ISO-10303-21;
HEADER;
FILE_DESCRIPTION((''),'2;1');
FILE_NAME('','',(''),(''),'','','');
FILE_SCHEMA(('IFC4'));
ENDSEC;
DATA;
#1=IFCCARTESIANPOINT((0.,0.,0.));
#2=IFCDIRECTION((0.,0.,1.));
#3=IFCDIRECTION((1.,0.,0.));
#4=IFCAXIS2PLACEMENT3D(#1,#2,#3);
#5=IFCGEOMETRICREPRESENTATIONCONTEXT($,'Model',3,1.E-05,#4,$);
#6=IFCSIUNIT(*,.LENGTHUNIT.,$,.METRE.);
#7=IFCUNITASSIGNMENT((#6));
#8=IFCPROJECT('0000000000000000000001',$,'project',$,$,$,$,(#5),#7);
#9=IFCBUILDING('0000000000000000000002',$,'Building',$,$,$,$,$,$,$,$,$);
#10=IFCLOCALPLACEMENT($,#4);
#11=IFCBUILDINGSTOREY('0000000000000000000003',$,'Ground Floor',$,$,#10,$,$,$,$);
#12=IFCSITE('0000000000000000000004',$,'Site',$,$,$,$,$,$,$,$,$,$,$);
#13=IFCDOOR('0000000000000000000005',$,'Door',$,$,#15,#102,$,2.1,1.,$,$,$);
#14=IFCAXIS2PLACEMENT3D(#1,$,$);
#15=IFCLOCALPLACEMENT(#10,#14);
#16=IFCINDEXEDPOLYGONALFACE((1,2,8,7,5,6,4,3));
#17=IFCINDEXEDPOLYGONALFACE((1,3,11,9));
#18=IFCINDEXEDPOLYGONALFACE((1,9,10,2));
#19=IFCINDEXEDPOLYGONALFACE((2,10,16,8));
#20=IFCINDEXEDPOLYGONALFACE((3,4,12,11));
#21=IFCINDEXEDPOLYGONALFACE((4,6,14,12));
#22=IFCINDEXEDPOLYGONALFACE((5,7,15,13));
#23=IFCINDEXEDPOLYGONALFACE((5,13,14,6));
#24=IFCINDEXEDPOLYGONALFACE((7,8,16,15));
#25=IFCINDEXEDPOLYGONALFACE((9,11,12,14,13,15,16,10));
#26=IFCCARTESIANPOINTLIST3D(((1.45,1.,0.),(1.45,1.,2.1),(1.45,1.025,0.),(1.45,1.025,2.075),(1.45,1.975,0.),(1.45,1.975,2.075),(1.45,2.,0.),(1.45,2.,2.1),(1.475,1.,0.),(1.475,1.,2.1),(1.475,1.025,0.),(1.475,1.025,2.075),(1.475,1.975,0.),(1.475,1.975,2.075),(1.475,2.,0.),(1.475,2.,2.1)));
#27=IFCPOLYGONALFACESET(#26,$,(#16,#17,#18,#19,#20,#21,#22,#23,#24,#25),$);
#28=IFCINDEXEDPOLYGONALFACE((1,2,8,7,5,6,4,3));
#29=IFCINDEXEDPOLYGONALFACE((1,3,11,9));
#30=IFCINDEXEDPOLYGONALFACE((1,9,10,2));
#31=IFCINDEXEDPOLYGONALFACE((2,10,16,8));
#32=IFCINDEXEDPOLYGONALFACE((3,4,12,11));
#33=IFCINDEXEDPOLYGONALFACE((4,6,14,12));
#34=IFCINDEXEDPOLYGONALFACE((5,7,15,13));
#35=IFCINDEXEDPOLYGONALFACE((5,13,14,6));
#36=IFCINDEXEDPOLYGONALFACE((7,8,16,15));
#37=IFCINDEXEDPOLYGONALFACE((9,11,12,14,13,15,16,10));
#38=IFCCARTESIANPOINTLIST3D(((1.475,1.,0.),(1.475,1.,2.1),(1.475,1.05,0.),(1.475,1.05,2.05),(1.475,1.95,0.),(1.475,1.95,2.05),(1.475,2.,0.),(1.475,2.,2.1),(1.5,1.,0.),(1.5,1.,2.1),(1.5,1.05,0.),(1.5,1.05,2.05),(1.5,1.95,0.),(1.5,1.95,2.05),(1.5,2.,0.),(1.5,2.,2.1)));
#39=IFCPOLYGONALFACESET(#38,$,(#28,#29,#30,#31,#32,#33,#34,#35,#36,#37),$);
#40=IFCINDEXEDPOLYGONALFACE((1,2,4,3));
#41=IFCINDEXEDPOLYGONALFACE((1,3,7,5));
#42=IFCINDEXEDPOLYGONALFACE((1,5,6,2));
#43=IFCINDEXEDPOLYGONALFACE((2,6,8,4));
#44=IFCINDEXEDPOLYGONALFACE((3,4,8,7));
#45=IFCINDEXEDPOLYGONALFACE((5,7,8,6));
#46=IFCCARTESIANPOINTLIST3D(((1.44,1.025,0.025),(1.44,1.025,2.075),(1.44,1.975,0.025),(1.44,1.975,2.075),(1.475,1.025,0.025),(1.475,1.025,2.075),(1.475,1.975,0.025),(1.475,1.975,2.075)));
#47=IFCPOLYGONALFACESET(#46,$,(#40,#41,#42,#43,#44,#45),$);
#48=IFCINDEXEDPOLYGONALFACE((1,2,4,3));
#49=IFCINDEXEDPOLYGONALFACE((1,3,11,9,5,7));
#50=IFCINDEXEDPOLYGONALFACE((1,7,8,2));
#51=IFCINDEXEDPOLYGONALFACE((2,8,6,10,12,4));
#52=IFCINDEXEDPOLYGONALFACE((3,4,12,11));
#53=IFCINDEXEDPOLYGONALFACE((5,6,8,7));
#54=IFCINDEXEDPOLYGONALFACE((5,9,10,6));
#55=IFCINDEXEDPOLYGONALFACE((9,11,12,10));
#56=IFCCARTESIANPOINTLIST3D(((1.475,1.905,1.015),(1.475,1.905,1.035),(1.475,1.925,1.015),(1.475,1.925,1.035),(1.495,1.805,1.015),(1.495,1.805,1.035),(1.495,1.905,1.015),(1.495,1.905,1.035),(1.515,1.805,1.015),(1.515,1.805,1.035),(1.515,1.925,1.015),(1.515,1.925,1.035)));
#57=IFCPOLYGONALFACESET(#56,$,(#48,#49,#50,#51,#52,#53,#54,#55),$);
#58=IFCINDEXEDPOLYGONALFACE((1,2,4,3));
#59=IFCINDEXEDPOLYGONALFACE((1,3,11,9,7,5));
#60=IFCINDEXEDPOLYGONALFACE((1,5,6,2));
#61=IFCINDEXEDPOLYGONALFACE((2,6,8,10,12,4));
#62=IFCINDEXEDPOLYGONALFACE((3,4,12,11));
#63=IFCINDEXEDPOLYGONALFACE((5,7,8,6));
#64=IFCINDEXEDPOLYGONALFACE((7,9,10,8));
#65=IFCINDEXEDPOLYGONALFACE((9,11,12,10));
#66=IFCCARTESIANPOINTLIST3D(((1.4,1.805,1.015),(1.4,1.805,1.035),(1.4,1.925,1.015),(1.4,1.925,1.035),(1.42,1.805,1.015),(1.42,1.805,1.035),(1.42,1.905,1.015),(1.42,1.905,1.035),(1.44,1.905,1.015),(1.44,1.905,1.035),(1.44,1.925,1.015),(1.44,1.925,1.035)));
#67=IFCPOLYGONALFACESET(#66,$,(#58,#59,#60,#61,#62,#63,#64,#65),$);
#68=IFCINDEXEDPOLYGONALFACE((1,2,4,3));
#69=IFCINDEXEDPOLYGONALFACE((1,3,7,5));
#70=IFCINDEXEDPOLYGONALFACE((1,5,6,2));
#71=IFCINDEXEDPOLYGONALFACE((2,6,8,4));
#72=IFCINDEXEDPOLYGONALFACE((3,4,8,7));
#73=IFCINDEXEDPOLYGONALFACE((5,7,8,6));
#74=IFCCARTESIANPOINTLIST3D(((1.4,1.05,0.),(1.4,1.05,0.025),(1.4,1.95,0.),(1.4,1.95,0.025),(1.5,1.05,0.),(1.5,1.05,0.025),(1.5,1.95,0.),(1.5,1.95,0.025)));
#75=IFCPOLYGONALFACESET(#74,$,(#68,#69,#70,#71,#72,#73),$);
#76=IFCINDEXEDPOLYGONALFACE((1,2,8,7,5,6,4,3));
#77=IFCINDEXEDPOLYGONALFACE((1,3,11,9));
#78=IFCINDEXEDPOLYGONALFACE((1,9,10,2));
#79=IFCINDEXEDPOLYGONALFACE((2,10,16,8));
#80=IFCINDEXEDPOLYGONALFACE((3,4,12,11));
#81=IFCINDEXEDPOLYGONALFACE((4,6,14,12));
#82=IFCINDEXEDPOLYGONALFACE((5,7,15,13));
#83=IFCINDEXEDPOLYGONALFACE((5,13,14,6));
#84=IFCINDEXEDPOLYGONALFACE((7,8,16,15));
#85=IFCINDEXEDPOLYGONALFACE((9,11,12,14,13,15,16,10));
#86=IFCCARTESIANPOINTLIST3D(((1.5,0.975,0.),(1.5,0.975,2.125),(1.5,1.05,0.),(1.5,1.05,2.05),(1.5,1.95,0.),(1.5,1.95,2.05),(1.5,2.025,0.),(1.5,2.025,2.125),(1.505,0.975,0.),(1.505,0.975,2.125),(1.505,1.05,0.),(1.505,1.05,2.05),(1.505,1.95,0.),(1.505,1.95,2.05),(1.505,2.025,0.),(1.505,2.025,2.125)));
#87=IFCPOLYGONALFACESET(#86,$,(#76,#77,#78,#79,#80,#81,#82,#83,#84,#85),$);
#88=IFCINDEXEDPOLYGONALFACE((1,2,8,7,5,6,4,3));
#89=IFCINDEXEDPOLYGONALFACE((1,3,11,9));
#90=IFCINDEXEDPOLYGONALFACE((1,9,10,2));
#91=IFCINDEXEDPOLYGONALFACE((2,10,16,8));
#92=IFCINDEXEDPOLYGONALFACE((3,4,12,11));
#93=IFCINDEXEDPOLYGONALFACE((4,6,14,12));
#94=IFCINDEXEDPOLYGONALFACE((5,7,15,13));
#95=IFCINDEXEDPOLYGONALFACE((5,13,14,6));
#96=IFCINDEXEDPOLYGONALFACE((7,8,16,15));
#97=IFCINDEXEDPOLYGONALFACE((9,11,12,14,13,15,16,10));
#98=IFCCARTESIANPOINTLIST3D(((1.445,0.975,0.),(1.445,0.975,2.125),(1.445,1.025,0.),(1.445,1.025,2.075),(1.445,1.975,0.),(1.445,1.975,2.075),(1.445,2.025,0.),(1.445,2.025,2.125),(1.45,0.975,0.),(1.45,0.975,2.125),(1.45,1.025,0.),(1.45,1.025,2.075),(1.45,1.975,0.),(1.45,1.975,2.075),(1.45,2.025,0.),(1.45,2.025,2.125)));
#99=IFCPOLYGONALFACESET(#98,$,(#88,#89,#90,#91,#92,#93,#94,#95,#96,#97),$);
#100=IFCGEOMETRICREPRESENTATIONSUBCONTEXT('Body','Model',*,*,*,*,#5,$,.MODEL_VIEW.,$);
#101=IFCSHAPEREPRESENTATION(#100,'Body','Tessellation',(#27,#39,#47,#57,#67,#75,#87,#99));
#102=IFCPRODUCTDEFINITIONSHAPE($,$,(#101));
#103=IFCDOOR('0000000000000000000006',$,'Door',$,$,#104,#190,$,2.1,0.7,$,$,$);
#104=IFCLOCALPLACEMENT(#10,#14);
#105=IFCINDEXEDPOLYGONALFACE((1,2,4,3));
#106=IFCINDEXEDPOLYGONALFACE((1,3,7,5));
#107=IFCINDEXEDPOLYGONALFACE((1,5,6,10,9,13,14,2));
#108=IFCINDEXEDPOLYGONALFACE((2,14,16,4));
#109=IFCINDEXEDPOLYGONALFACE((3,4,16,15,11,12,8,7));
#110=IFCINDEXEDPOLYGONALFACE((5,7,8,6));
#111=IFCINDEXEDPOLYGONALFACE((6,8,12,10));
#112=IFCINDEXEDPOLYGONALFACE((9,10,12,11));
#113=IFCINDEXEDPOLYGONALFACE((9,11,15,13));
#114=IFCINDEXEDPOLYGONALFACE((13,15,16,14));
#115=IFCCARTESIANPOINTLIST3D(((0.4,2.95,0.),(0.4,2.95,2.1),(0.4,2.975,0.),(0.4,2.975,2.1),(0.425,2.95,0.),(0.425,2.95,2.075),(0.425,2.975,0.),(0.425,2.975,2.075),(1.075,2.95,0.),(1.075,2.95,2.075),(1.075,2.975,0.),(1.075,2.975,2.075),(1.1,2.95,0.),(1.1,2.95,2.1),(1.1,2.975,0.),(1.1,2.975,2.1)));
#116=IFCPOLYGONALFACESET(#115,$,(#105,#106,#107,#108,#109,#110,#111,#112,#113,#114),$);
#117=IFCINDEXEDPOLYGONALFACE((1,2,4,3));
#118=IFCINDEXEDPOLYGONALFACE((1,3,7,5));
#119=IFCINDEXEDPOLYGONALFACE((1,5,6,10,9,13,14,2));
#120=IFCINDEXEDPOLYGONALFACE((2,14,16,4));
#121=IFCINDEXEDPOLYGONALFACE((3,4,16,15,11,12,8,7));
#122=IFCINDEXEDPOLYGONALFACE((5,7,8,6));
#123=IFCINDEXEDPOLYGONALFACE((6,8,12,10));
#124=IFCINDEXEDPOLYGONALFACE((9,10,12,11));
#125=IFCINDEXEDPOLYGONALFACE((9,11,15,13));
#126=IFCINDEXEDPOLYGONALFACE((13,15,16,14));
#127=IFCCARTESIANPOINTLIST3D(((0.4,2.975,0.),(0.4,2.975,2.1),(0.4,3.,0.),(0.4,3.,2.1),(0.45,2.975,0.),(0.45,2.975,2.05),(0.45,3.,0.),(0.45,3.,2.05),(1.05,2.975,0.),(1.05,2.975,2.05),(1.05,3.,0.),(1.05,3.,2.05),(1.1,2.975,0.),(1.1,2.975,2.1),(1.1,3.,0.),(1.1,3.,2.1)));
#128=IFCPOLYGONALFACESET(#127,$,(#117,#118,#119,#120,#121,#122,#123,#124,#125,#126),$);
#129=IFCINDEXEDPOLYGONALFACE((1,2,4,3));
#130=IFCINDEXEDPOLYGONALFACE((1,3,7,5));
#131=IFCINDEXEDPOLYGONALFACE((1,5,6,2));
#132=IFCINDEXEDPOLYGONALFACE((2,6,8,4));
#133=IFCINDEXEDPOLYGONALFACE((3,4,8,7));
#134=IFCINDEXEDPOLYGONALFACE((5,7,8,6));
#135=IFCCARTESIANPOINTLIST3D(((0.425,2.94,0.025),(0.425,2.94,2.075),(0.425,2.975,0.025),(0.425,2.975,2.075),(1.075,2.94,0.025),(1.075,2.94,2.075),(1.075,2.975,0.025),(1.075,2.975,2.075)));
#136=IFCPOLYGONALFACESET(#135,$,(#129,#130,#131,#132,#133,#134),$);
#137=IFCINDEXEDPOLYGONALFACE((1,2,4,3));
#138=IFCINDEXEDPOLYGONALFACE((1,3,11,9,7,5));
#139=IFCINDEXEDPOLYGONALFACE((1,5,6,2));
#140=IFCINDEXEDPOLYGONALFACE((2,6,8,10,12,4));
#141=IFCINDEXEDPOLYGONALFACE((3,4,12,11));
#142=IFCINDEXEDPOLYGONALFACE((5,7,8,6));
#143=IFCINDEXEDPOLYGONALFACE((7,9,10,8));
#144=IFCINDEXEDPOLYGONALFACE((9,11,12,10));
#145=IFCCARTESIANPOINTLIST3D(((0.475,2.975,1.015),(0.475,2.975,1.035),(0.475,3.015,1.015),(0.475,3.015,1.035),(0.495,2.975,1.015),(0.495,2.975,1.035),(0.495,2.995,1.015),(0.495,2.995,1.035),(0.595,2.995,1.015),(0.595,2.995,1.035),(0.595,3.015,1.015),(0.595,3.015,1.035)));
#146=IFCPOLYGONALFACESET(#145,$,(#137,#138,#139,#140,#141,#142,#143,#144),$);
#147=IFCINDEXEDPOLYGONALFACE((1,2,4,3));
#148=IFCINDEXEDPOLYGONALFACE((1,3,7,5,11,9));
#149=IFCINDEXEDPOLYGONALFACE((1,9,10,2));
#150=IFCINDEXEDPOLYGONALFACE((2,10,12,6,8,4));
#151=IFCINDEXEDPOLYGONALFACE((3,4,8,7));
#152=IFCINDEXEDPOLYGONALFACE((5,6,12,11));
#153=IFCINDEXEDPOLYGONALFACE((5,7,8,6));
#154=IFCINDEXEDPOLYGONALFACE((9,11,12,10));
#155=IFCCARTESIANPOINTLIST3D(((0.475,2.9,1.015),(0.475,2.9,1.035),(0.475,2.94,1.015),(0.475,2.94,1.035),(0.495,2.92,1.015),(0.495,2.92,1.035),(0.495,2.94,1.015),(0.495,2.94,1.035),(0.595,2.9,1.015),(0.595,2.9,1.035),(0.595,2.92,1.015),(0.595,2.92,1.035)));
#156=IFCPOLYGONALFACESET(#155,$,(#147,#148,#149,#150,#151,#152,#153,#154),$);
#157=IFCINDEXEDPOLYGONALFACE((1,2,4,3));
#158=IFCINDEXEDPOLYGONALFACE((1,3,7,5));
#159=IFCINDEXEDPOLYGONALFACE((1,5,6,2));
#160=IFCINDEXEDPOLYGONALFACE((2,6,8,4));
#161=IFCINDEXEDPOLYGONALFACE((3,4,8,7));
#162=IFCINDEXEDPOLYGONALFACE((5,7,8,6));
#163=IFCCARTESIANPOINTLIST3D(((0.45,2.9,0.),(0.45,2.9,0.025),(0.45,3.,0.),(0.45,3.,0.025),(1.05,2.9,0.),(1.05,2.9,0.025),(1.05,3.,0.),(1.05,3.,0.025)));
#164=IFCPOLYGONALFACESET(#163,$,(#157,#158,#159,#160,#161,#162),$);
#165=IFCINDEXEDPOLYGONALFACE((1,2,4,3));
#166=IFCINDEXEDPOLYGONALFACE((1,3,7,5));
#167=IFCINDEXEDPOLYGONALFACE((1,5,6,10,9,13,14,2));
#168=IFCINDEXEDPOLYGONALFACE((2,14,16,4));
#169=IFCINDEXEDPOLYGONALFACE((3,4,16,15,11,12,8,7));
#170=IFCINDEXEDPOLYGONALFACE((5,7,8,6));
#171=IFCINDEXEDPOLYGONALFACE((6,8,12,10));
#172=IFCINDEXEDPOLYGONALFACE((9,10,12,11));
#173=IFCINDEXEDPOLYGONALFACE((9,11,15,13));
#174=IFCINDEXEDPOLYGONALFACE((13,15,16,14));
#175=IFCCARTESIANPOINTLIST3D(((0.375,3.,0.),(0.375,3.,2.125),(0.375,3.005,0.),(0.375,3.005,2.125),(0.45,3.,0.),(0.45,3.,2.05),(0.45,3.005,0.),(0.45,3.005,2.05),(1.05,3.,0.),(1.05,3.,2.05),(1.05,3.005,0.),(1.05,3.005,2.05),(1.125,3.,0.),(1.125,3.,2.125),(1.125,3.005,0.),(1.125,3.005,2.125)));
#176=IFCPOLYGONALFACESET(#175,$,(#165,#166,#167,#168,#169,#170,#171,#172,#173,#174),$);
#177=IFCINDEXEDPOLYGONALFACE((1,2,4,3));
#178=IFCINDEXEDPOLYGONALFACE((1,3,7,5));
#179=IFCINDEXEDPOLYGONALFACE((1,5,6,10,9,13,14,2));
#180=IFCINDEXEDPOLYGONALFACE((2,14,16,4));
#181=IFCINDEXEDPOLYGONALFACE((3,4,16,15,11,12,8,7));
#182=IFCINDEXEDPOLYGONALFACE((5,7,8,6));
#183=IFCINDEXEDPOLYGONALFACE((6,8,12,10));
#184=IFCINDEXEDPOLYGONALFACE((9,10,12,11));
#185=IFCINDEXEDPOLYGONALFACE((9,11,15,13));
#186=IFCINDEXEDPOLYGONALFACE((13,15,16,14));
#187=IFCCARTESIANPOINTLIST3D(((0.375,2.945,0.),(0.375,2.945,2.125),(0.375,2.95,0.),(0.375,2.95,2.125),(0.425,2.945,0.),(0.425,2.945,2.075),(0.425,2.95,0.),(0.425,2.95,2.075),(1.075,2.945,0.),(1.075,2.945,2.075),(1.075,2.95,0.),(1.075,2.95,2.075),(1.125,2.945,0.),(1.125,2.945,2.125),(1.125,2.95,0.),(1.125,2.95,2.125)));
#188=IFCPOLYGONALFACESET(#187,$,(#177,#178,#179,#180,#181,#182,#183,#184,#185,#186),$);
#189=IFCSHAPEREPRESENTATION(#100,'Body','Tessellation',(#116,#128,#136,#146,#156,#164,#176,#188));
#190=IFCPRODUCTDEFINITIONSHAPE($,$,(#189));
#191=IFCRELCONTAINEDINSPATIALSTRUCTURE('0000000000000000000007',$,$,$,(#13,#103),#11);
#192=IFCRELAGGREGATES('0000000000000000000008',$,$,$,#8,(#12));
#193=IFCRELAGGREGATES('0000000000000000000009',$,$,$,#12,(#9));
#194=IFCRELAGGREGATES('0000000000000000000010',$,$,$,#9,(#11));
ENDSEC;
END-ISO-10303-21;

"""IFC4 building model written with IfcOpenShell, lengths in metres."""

from ifc_helpers import new_model, si_unit, frame, origin_with_axes, place, context, subcontext, project, spatial, line, indexed_curve, outline, extrude, element, save


model = new_model("IFC4")

# Units and contexts
model_context = context("Model", 3, precision=1e-05, world=origin_with_axes())
body_context = subcontext(model_context, "Body", "Model", "MODEL_VIEW")
ifc_project = project(units=[si_unit("LENGTHUNIT", "METRE")], contexts=[model_context])

# Site, building, storey
site = spatial("IfcSite", under=ifc_project, Name="Site")
building = spatial("IfcBuilding", under=site, Name="Building")
storey_placement = place(None, origin_with_axes())
storey = spatial("IfcBuildingStorey", under=building, at=storey_placement, Name="Ground Floor")

# Doors
door_1_placement = place(storey_placement, frame((1.5, 1.0, 0.0), z_axis=(0.0, 0.0, 1.0), x_axis=(0.0, 1.0, 0.0)))
element("IfcDoor", 1, at=door_1_placement, inside=storey, Name="Door", OverallHeight=2.1, OverallWidth=1.0, context=body_context, shape_type="SweptSolid", body=[
    extrude(outline(indexed_curve([(0.0, 0.0), (0.0, 2.1), (1.0, 2.1), (1.0, 0.0), (0.975, 0.0), (0.975, 2.075), (0.025, 2.075), (0.025, 0.0)], segments=[line(1, 2, 3, 4, 5, 6, 7, 8, 1)])), frame((0.0, 0.025, 0.0), z_axis=(0.0, -1.0, 0.0), x_axis=(1.0, 0.0, 0.0)), (0.0, 0.0, -1.0), 0.025),
    extrude(outline(indexed_curve([(0.0, 0.0), (0.0, 2.1), (1.0, 2.1), (1.0, 0.0), (0.95, 0.0), (0.95, 2.05), (0.05, 2.05), (0.05, 0.0)], segments=[line(1, 2, 3, 4, 5, 6, 7, 8, 1)])), frame((0.0, 0.0, 0.0), z_axis=(0.0, -1.0, 0.0), x_axis=(1.0, 0.0, 0.0)), (0.0, 0.0, -1.0), 0.025),
    extrude(outline(indexed_curve([(0.0, 0.0), (0.95, 0.0), (0.95, 0.035), (0.0, 0.035)], segments=[line(1, 2, 3, 4, 1)])), frame((0.025, 0.025, 0.025), z_axis=(0.0, 0.0, 1.0), x_axis=(1.0, 0.0, 0.0)), (0.0, 0.0, 1.0), 2.05),
    extrude(outline(indexed_curve([(0.0, 0.0), (0.0, -0.04), (-0.12, -0.04), (-0.12, -0.02), (-0.02, -0.02), (-0.02, 0.0)], segments=[line(1, 2, 3, 4, 5, 6, 1)])), frame((0.925, 0.025, 1.015), z_axis=(0.0, 0.0, 1.0), x_axis=(1.0, 0.0, 0.0)), (0.0, 0.0, 1.0), 0.02),
    extrude(outline(indexed_curve([(0.0, 0.0), (0.0, 0.04), (-0.12, 0.04), (-0.12, 0.02), (-0.02, 0.02), (-0.02, 0.0)], segments=[line(1, 2, 3, 4, 5, 6, 1)])), frame((0.925, 0.06, 1.015), z_axis=(0.0, 0.0, 1.0), x_axis=(1.0, 0.0, 0.0)), (0.0, 0.0, 1.0), 0.02),
    extrude(outline(indexed_curve([(0.0, 0.0), (0.9, 0.0), (0.9, 0.1), (0.0, 0.1)], segments=[line(1, 2, 3, 4, 1)])), frame((0.05, 0.0, 0.0), z_axis=(0.0, 0.0, 1.0), x_axis=(1.0, 0.0, 0.0)), (0.0, 0.0, 1.0), 0.025),
    extrude(outline(indexed_curve([(0.0, 0.0), (0.0, 2.125), (1.05, 2.125), (1.05, 0.0), (0.975, 0.0), (0.975, 2.05), (0.075, 2.05), (0.075, 0.0)], segments=[line(1, 2, 3, 4, 5, 6, 7, 8, 1)])), frame((-0.025, -0.005, 0.0), z_axis=(0.0, -1.0, 0.0), x_axis=(1.0, 0.0, 0.0)), (0.0, 0.0, -1.0), 0.005),
    extrude(outline(indexed_curve([(0.0, 0.0), (0.0, 2.125), (1.05, 2.125), (1.05, 0.0), (1.0, 0.0), (1.0, 2.075), (0.05, 2.075), (0.05, 0.0)], segments=[line(1, 2, 3, 4, 5, 6, 7, 8, 1)])), frame((-0.025, 0.05, 0.0), z_axis=(0.0, -1.0, 0.0), x_axis=(1.0, 0.0, 0.0)), (0.0, 0.0, -1.0), 0.005),
])
door_2_placement = place(storey_placement, frame((1.1, 3.0, 0.0), z_axis=(0.0, 0.0, 1.0), x_axis=(-1.0, 0.0, 0.0)))
element("IfcDoor", 2, at=door_2_placement, inside=storey, Name="Door", OverallHeight=2.1, OverallWidth=0.7, context=body_context, shape_type="SweptSolid", body=[
    extrude(outline(indexed_curve([(0.0, 0.0), (0.0, 2.1), (0.7, 2.1), (0.7, 0.0), (0.675, 0.0), (0.675, 2.075), (0.025, 2.075), (0.025, 0.0)], segments=[line(1, 2, 3, 4, 5, 6, 7, 8, 1)])), frame((0.0, 0.025, 0.0), z_axis=(0.0, -1.0, 0.0), x_axis=(1.0, 0.0, 0.0)), (0.0, 0.0, -1.0), 0.025),
    extrude(outline(indexed_curve([(0.0, 0.0), (0.0, 2.1), (0.7, 2.1), (0.7, 0.0), (0.65, 0.0), (0.65, 2.05), (0.05, 2.05), (0.05, 0.0)], segments=[line(1, 2, 3, 4, 5, 6, 7, 8, 1)])), frame((0.0, 0.0, 0.0), z_axis=(0.0, -1.0, 0.0), x_axis=(1.0, 0.0, 0.0)), (0.0, 0.0, -1.0), 0.025),
    extrude(outline(indexed_curve([(0.0, 0.0), (0.65, 0.0), (0.65, 0.035), (0.0, 0.035)], segments=[line(1, 2, 3, 4, 1)])), frame((0.025, 0.025, 0.025), z_axis=(0.0, 0.0, 1.0), x_axis=(1.0, 0.0, 0.0)), (0.0, 0.0, 1.0), 2.05),
    extrude(outline(indexed_curve([(0.0, 0.0), (0.0, -0.04), (-0.12, -0.04), (-0.12, -0.02), (-0.02, -0.02), (-0.02, 0.0)], segments=[line(1, 2, 3, 4, 5, 6, 1)])), frame((0.625, 0.025, 1.015), z_axis=(0.0, 0.0, 1.0), x_axis=(1.0, 0.0, 0.0)), (0.0, 0.0, 1.0), 0.02),
    extrude(outline(indexed_curve([(0.0, 0.0), (0.0, 0.04), (-0.12, 0.04), (-0.12, 0.02), (-0.02, 0.02), (-0.02, 0.0)], segments=[line(1, 2, 3, 4, 5, 6, 1)])), frame((0.625, 0.06, 1.015), z_axis=(0.0, 0.0, 1.0), x_axis=(1.0, 0.0, 0.0)), (0.0, 0.0, 1.0), 0.02),
    extrude(outline(indexed_curve([(0.0, 0.0), (0.6, 0.0), (0.6, 0.1), (0.0, 0.1)], segments=[line(1, 2, 3, 4, 1)])), frame((0.05, 0.0, 0.0), z_axis=(0.0, 0.0, 1.0), x_axis=(1.0, 0.0, 0.0)), (0.0, 0.0, 1.0), 0.025),
    extrude(outline(indexed_curve([(0.0, 0.0), (0.0, 2.125), (0.75, 2.125), (0.75, 0.0), (0.675, 0.0), (0.675, 2.05), (0.075, 2.05), (0.075, 0.0)], segments=[line(1, 2, 3, 4, 5, 6, 7, 8, 1)])), frame((-0.025, -0.005, 0.0), z_axis=(0.0, -1.0, 0.0), x_axis=(1.0, 0.0, 0.0)), (0.0, 0.0, -1.0), 0.005),
    extrude(outline(indexed_curve([(0.0, 0.0), (0.0, 2.125), (0.75, 2.125), (0.75, 0.0), (0.7, 0.0), (0.7, 2.075), (0.05, 2.075), (0.05, 0.0)], segments=[line(1, 2, 3, 4, 5, 6, 7, 8, 1)])), frame((-0.025, 0.05, 0.0), z_axis=(0.0, -1.0, 0.0), x_axis=(1.0, 0.0, 0.0)), (0.0, 0.0, -1.0), 0.005),
])

save(model, "model.ifc")
